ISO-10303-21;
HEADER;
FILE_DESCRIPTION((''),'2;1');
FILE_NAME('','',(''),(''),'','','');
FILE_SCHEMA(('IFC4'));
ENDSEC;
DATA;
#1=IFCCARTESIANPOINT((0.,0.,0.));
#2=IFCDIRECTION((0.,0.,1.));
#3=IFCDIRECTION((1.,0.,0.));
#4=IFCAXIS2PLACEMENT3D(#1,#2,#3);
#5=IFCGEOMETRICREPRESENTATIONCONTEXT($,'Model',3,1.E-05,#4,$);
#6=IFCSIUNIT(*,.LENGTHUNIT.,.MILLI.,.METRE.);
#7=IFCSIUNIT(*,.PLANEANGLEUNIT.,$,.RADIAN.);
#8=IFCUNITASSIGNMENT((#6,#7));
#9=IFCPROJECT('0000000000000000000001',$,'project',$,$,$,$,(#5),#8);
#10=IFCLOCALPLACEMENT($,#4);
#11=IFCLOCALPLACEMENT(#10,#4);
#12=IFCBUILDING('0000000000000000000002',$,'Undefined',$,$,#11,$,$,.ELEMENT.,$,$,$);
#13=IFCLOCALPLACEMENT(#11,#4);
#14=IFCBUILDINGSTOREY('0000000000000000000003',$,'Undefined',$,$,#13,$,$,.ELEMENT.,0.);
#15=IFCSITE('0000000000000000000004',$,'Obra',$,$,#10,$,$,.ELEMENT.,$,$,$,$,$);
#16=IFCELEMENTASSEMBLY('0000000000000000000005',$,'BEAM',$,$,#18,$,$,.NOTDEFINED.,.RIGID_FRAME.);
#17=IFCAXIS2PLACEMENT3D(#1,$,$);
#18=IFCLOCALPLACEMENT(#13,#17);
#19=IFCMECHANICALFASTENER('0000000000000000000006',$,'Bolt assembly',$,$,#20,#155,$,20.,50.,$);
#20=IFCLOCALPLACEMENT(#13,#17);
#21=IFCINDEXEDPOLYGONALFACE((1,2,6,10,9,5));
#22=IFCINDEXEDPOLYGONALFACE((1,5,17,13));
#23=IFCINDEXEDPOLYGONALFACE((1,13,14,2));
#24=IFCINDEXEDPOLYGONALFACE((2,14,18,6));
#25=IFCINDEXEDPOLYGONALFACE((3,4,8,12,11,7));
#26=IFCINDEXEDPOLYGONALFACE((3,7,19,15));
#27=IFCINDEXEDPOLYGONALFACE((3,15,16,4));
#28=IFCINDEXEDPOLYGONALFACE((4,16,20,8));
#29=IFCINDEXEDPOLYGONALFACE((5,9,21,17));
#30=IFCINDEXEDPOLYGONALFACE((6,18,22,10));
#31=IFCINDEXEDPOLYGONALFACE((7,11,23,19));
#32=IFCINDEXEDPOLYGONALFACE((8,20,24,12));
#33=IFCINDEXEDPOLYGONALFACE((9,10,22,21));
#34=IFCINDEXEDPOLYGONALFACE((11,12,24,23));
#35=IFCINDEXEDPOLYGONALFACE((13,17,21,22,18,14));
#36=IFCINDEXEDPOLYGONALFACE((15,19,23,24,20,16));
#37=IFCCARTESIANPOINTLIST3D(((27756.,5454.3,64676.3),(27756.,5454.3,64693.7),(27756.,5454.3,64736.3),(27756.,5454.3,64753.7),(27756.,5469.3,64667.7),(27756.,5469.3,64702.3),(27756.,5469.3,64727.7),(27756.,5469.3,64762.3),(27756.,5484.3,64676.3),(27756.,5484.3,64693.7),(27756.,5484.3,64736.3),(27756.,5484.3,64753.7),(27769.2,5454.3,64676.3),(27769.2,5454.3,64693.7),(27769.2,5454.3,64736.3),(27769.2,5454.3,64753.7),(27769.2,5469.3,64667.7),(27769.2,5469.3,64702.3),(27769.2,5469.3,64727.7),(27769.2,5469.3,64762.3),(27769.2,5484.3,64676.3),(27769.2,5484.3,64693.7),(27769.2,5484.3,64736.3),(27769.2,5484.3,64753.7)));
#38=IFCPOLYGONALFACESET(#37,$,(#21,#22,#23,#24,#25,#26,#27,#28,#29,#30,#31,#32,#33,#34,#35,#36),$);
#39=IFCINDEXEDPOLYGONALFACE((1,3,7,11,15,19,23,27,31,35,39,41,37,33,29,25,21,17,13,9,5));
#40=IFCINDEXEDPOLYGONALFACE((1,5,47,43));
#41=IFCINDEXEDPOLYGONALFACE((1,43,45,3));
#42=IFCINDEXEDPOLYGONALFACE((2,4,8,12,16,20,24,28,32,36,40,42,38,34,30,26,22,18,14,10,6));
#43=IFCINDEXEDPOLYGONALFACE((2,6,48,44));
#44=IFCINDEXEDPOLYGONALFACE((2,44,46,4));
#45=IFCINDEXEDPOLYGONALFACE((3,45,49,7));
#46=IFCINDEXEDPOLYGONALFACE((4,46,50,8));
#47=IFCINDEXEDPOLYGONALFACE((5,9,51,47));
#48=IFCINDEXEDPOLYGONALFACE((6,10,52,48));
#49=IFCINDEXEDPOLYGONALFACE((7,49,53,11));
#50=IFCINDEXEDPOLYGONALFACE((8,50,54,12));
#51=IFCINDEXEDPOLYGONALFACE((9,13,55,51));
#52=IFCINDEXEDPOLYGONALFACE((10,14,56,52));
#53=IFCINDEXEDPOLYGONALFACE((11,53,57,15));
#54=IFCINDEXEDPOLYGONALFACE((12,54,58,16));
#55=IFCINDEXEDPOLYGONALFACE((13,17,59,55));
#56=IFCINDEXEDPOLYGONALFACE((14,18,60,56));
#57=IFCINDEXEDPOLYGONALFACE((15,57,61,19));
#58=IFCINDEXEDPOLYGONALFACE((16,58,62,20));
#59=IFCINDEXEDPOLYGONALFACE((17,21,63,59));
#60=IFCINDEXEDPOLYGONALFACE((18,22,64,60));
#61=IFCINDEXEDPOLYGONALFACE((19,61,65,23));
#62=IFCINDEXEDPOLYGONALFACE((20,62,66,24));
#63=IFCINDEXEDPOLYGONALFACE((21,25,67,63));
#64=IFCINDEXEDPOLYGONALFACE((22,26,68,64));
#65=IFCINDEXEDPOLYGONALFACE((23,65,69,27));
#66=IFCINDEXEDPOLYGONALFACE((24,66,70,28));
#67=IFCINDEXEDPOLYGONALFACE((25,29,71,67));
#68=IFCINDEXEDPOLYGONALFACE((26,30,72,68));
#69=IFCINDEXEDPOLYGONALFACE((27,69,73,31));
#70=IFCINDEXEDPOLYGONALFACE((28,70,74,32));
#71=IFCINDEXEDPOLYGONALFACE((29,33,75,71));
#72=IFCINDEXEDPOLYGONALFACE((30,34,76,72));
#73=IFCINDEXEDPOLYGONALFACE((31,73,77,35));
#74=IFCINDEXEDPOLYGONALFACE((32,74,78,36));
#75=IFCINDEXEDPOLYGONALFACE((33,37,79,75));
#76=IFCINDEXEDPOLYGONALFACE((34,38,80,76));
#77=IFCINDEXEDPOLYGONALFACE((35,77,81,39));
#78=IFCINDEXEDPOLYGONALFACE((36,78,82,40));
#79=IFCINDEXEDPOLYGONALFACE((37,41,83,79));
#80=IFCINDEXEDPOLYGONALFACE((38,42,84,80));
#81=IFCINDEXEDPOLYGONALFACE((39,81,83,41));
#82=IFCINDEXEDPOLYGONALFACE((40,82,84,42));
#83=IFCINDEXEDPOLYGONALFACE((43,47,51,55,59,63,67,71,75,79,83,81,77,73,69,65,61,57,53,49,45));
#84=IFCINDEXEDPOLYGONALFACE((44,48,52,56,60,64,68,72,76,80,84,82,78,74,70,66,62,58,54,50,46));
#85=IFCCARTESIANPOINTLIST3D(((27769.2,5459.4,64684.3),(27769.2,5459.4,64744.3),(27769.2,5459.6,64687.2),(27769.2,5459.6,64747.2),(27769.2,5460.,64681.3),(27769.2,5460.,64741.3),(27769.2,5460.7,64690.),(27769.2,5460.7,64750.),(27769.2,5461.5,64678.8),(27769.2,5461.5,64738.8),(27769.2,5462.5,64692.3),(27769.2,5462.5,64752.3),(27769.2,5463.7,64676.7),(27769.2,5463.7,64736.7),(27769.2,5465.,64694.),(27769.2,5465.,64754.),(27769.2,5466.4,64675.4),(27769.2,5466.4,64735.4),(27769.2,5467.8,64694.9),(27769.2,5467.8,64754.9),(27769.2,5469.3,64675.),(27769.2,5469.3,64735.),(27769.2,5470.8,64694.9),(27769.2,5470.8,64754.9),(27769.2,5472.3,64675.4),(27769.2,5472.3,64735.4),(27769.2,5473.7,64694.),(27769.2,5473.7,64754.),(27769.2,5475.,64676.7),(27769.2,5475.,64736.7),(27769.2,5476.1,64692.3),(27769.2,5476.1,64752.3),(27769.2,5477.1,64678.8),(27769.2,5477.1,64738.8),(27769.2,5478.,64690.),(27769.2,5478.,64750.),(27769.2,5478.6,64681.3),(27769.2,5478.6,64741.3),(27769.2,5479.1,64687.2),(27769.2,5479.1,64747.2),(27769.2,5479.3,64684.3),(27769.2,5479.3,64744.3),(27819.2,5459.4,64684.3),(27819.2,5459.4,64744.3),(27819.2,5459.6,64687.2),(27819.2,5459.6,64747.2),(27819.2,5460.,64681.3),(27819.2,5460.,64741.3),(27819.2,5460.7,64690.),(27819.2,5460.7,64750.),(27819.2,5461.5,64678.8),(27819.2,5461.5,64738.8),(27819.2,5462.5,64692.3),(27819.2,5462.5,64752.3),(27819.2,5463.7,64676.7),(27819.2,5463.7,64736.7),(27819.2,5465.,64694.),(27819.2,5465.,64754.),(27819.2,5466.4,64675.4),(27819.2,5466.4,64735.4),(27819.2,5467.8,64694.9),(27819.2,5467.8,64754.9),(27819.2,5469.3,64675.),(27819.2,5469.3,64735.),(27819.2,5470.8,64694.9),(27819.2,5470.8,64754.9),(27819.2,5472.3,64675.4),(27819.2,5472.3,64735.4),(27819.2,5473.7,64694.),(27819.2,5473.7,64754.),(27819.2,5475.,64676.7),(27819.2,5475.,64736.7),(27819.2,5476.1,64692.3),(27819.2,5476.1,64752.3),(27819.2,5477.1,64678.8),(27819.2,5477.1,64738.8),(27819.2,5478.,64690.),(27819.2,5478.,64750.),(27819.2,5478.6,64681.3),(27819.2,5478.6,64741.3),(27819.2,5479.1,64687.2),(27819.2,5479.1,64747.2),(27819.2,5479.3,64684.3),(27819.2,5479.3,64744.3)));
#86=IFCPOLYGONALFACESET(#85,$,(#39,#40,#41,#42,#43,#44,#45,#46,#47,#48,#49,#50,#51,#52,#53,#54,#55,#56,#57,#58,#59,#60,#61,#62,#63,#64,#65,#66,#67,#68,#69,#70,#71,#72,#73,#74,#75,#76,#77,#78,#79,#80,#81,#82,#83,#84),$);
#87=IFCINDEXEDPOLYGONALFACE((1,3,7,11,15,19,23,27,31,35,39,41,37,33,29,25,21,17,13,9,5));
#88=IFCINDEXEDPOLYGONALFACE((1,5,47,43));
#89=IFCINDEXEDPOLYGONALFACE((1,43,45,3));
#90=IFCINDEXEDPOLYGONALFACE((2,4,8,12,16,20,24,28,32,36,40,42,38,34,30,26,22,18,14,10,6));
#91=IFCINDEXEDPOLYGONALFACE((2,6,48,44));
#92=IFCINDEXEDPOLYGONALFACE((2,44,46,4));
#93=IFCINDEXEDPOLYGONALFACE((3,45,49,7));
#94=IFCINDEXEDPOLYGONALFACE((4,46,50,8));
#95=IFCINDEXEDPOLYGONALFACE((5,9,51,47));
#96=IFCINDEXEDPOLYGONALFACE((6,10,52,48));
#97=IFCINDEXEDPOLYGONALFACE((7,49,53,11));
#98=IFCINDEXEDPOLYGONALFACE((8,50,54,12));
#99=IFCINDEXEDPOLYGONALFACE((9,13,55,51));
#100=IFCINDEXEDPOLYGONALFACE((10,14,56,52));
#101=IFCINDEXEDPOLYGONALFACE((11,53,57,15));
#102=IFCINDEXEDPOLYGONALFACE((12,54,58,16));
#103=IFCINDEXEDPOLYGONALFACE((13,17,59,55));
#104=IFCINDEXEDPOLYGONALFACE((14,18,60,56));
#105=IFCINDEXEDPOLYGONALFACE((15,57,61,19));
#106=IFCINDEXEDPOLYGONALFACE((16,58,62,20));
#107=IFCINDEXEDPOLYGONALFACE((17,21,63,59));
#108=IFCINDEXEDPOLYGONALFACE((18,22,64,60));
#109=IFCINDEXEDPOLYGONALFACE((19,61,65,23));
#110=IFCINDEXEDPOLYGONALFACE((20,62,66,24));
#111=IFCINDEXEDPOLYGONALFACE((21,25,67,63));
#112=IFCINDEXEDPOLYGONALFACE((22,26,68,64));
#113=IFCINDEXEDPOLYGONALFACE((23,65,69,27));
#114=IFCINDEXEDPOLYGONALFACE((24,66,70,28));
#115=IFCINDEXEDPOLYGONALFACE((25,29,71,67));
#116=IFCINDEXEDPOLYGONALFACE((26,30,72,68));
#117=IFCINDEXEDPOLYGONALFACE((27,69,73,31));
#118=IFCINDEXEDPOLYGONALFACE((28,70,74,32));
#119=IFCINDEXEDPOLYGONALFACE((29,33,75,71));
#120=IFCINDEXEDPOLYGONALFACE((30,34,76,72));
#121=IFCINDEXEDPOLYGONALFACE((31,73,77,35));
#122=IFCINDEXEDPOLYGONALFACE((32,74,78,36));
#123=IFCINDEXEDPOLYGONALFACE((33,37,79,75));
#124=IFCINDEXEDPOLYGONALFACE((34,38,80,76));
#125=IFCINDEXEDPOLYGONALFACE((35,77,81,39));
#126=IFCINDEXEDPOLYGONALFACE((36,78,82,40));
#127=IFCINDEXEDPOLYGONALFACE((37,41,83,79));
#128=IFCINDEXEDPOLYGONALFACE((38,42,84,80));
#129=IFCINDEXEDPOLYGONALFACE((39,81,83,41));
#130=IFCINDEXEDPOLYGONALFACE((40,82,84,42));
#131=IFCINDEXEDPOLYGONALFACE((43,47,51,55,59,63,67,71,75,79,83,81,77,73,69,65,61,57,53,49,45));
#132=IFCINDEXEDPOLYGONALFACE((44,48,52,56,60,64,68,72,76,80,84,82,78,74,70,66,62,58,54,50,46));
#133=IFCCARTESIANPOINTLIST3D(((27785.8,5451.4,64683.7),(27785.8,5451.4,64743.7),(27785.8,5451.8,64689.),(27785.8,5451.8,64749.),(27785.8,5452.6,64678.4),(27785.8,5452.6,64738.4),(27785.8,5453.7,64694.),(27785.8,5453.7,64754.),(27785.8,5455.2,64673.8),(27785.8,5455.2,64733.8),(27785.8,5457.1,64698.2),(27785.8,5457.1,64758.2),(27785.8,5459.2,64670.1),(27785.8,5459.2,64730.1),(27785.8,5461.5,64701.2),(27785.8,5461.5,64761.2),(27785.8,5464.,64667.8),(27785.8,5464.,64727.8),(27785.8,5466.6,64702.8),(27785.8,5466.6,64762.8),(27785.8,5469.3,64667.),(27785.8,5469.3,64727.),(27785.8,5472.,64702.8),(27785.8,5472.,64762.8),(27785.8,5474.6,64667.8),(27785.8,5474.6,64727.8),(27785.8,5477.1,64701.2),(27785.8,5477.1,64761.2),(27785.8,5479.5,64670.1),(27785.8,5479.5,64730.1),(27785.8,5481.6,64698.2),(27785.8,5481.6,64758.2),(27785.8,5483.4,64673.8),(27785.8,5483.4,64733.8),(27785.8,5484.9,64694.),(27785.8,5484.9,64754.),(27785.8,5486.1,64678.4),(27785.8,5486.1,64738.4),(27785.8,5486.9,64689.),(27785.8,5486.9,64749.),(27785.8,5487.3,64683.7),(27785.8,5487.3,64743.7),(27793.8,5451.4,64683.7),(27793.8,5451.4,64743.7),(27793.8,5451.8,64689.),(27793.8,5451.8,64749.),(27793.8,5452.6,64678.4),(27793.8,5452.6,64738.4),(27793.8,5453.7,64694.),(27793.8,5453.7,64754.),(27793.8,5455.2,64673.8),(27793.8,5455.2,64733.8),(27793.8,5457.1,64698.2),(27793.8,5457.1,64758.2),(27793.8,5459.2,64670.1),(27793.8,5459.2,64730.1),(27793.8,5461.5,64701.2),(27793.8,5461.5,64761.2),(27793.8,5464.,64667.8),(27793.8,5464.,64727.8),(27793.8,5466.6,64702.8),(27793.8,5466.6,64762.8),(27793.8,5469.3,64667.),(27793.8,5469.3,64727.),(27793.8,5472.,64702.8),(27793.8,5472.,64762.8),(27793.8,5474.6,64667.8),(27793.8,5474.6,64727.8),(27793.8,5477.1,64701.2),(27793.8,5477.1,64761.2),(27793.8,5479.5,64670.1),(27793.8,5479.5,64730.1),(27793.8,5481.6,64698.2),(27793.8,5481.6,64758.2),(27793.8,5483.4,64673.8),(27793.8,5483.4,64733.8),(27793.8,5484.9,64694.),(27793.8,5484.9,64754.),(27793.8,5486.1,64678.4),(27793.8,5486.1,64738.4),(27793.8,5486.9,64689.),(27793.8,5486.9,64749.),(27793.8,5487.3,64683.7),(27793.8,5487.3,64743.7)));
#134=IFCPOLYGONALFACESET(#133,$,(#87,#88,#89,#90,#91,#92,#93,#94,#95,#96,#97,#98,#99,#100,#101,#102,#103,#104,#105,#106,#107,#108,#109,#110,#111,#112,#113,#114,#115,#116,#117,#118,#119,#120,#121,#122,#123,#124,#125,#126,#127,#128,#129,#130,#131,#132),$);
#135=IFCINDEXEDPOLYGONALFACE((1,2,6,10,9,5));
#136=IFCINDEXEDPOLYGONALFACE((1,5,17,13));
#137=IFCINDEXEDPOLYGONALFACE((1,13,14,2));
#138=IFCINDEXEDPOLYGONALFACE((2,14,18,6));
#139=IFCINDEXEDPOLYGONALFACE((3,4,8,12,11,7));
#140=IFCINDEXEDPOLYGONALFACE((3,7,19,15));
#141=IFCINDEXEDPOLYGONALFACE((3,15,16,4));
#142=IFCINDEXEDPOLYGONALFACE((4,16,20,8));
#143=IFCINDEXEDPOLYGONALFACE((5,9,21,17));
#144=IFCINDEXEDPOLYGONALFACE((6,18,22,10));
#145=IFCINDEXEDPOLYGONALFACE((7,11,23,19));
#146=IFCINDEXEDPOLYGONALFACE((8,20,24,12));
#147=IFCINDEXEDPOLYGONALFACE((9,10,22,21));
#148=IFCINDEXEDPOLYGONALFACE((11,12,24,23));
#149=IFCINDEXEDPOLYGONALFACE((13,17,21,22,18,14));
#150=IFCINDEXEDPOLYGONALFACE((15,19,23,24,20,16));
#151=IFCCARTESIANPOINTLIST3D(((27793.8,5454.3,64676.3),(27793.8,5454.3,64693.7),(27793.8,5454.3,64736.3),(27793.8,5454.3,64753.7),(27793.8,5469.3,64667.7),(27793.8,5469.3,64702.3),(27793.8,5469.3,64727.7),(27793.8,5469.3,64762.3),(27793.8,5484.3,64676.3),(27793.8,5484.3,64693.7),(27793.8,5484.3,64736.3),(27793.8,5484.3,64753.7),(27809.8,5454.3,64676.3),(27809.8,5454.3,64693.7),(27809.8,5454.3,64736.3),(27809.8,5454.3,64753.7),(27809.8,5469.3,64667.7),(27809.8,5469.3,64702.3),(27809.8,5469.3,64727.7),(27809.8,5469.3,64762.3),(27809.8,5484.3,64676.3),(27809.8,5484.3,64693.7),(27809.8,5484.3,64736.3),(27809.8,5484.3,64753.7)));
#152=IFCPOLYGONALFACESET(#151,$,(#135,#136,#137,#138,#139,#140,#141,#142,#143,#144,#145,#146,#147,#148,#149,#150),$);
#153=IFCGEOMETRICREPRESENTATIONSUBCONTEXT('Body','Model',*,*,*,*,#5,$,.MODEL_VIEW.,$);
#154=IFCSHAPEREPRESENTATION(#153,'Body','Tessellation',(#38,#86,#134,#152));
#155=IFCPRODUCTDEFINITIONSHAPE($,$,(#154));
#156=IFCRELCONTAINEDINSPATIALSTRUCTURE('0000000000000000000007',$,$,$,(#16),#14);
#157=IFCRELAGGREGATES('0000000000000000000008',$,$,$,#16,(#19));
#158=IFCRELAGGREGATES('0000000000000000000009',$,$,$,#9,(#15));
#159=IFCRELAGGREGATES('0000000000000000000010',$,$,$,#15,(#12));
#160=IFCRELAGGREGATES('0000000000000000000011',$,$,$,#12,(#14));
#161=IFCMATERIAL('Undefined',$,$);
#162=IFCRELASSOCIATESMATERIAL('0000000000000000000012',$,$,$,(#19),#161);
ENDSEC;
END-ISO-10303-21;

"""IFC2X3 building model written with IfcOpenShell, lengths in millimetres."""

from ifc_helpers import new_model, si_unit, frame, origin_with_axes, origin_2d_with_axis, place, context, subcontext, project, spatial, polyline, circle, outline, extrude, source, transform, mapped, material, element, aggregate, save


model = new_model("IFC2X3")

# Units and contexts
model_context = context("Model", 3, precision=1e-05, world=origin_with_axes())
body_context = subcontext(model_context, "Body", "Model", "MODEL_VIEW")
ifc_project = project(units=[si_unit("LENGTHUNIT", "METRE", prefix="MILLI"), si_unit("PLANEANGLEUNIT", "RADIAN")], contexts=[model_context])

# Site, building, storey
site_placement = place(None, origin_with_axes())
site = spatial("IfcSite", under=ifc_project, at=site_placement, Name="Obra", CompositionType="ELEMENT")
building_placement = place(site_placement, origin_with_axes())
building = spatial("IfcBuilding", under=site, at=building_placement, Name="Undefined", CompositionType="ELEMENT")
storey_placement = place(building_placement, origin_with_axes())
storey = spatial("IfcBuildingStorey", under=building, at=storey_placement, Name="Undefined", CompositionType="ELEMENT", Elevation=0.0)

# Shared definitions
ifc_material = material(Name="Undefined")

# Element assembly, mechanical fastener
assembly_1_placement = place(storey_placement, origin_with_axes())
assembly_1 = element("IfcElementAssembly", 1, at=assembly_1_placement, inside=storey, Name="BEAM", AssemblyPlace="NOTDEFINED", PredefinedType="RIGID_FRAME")
shared_shape_1 = source(origin_with_axes(), body_context, "Body", "SweptSolid", [
    extrude(outline(polyline([(17.3, 0.0), (8.7, 15.0), (-8.7, 15.0), (-17.3, 0.0), (-8.7, -15.0), (8.7, -15.0), (17.3, 0.0)])), frame((0.0, -26.5, 0.0), z_axis=(0.0, 1.0, 0.0), x_axis=(1.0, 0.0, 0.0)), (0.0, 0.0, 1.0), 13.2),
    extrude(circle(Radius=10.0, at=origin_2d_with_axis()), frame((0.0, -13.3, 0.0), z_axis=(0.0, 1.0, 0.0), x_axis=(1.0, 0.0, 0.0)), (0.0, 0.0, 1.0), 50.0),
    extrude(circle(Radius=18.0, at=origin_2d_with_axis()), frame((0.0, 3.3, 0.0), z_axis=(0.0, 1.0, 0.0), x_axis=(1.0, 0.0, 0.0)), (0.0, 0.0, 1.0), 8.0),
    extrude(outline(polyline([(17.3, 0.0), (8.7, 15.0), (-8.7, 15.0), (-17.3, 0.0), (-8.7, -15.0), (8.7, -15.0), (17.3, 0.0)])), frame((0.0, 11.3, 0.0), z_axis=(0.0, 1.0, 0.0), x_axis=(1.0, 0.0, 0.0)), (0.0, 0.0, 1.0), 16.0),
])
mechanical_fastener_1_placement = place(assembly_1_placement, frame((27782.5, 5509.3, 64850.0), z_axis=(0.000002, -1.0, 0.0), x_axis=(0.0, 0.0, -1.0)))
mechanical_fastener_1 = element("IfcMechanicalFastener", 2, at=mechanical_fastener_1_placement, material=ifc_material, Name="Bolt assembly", NominalDiameter=20.0, NominalLength=50.0, context=body_context, shape_type="MappedRepresentation", body=[
    mapped(shared_shape_1, transform((105.0, 0.0, 40.0))),
    mapped(shared_shape_1, transform((165.0, 0.0, 40.0))),
])
aggregate(assembly_1, [mechanical_fastener_1])

save(model, "model.ifc")
